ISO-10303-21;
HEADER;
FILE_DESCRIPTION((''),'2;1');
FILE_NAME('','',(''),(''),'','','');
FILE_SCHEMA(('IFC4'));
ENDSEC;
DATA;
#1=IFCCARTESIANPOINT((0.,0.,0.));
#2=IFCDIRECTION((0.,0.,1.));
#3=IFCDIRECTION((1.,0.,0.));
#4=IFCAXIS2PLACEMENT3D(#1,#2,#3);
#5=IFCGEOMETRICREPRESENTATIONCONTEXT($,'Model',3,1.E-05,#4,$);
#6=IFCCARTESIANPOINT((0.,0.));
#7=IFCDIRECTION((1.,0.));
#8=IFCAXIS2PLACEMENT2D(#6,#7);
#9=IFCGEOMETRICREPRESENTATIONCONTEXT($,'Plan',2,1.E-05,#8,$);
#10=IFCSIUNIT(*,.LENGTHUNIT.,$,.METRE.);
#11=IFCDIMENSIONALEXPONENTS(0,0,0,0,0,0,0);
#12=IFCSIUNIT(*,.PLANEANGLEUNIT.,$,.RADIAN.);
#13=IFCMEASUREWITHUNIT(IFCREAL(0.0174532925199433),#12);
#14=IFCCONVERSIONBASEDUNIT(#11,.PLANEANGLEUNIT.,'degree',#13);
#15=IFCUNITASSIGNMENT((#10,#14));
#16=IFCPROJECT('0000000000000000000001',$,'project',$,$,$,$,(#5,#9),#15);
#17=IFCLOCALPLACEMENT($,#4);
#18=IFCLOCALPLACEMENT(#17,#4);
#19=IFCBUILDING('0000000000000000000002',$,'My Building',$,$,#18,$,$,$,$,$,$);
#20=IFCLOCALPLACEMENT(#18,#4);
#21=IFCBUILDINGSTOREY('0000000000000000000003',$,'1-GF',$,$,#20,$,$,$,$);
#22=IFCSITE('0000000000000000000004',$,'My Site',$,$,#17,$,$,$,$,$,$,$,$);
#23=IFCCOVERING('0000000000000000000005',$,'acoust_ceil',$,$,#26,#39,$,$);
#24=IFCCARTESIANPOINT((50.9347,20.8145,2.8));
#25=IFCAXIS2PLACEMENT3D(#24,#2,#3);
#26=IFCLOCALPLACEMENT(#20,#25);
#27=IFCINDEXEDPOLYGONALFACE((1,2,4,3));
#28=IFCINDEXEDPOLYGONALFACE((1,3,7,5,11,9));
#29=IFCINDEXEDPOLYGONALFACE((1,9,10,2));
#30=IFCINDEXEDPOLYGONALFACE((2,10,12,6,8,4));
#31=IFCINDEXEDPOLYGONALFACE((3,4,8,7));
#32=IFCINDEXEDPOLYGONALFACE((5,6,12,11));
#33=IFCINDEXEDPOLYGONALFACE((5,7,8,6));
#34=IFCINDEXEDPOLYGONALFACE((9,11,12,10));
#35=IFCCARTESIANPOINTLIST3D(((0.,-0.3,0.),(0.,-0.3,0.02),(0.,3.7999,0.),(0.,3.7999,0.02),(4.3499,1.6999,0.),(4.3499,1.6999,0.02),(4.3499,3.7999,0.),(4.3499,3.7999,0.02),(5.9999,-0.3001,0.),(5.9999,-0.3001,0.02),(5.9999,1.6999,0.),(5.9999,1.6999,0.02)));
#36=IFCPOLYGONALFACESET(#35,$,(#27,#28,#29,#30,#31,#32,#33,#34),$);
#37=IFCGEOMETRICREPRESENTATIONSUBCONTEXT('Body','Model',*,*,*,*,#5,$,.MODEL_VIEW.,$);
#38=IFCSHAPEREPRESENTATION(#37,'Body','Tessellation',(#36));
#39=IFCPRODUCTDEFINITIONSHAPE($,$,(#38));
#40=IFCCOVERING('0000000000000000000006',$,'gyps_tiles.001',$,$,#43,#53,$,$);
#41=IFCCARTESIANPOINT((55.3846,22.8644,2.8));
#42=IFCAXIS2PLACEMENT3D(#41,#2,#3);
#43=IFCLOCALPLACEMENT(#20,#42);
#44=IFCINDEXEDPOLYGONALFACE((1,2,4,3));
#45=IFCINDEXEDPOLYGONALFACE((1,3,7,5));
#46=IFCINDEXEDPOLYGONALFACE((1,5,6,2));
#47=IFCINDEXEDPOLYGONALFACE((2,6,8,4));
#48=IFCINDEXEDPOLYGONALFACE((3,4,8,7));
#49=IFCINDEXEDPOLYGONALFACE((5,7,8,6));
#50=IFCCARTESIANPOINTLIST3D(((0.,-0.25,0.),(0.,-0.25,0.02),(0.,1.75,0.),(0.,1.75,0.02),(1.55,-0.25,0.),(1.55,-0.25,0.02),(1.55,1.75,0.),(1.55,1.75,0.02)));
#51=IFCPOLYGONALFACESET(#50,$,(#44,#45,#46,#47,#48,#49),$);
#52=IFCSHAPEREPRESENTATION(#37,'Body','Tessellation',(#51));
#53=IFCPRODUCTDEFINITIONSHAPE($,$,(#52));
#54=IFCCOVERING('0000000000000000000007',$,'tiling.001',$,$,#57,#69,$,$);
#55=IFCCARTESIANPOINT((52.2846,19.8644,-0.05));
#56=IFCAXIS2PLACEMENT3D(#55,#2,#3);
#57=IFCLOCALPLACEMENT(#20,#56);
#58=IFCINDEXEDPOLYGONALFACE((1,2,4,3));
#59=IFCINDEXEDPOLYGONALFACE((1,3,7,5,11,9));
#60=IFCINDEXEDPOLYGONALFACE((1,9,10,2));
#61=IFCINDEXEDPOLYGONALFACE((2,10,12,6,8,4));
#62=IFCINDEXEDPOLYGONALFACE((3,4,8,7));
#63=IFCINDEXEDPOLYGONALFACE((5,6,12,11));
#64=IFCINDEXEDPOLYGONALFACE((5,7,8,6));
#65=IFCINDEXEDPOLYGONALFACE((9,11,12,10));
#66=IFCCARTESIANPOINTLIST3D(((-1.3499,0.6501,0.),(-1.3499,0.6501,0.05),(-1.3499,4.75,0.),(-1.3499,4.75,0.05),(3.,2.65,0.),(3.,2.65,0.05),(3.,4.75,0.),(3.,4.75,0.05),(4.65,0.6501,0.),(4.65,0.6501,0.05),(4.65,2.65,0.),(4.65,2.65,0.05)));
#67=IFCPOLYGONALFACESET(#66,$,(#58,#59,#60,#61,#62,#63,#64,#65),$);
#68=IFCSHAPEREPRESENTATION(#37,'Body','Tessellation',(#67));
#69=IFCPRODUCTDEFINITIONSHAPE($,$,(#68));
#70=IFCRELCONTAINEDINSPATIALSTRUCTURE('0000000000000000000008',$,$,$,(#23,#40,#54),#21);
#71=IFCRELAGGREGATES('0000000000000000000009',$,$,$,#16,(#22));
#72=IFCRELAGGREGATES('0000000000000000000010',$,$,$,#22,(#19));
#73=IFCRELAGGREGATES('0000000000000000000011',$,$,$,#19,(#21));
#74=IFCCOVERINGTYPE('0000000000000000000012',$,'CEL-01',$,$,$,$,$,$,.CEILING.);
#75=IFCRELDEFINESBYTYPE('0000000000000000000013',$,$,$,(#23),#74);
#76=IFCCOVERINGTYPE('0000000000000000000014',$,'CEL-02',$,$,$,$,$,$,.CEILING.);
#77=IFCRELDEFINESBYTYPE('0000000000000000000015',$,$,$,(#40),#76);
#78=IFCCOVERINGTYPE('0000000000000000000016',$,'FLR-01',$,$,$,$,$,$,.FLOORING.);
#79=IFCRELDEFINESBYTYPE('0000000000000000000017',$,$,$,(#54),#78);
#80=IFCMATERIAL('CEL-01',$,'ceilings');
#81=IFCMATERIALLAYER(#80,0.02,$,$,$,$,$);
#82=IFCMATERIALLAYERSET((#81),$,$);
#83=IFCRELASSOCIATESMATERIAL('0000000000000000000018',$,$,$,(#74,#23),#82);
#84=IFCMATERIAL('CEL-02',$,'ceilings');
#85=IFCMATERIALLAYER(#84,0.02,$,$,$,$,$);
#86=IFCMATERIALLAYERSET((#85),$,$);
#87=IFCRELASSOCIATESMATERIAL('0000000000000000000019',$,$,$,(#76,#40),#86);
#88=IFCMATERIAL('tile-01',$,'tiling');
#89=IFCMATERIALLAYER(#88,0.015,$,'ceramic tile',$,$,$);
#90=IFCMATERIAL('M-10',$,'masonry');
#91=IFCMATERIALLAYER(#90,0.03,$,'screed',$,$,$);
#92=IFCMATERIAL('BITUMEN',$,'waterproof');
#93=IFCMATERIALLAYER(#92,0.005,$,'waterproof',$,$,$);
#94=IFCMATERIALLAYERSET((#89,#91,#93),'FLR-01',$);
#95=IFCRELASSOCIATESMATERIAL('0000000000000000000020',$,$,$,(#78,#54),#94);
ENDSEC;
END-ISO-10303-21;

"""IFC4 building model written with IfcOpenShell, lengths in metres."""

from ifc_helpers import new_model, entity, si_unit, converted_unit, frame, origin_with_axes, origin_2d_with_axis, place, context, subcontext, project, spatial, line, indexed_curve, outline, extrude, material, layer, layer_set, layer_usage, type_object, element, save


model = new_model("IFC4")

# Units and contexts
model_context = context("Model", 3, precision=1e-05, world=origin_with_axes())
plan_context = context("Plan", 2, precision=1e-05, world=origin_2d_with_axis())
body_context_1 = subcontext(model_context, "Body", "Model", "MODEL_VIEW")
ifc_project = project(units=[si_unit("LENGTHUNIT", "METRE"), converted_unit("PLANEANGLEUNIT", "degree", entity("IfcReal", 0.0174532925199433), si_unit("PLANEANGLEUNIT", "RADIAN"), dimensions=[0, 0, 0, 0, 0, 0, 0])], contexts=[model_context, plan_context])

# Site, building, storey
site_placement = place(None, origin_with_axes())
site = spatial("IfcSite", under=ifc_project, at=site_placement, Name="My Site")
building_placement = place(site_placement, origin_with_axes())
building = spatial("IfcBuilding", under=site, at=building_placement, Name="My Building")
storey_placement = place(building_placement, origin_with_axes())
storey = spatial("IfcBuildingStorey", under=building, at=storey_placement, Name="1-GF")

# Coverings
ifc_material_1 = material(Name="CEL-01", Category="ceilings")
ifc_layer_1 = layer(ifc_material_1, 0.02)
ifc_layer_set_1 = layer_set([ifc_layer_1])
ifc_layer_usage_1 = layer_usage(ifc_layer_set_1, "AXIS3", "POSITIVE", 0.0)
covering_type_1 = type_object("IfcCoveringType", Name="CEL-01", PredefinedType="CEILING", material=ifc_layer_set_1)
covering_1_placement = place(storey_placement, frame((50.9347, 20.8145, 2.8), z_axis=(0.0, 0.0, 1.0), x_axis=(1.0, 0.0, 0.0)))
element("IfcCovering", 1, at=covering_1_placement, inside=storey, type_object=covering_type_1, material=ifc_layer_usage_1, Name="acoust_ceil", context=body_context_1, shape_type="SweptSolid", body=[
    extrude(outline(indexed_curve([(0.0, -0.3), (4.3499, 3.7999), (0.0, 3.7999), (4.3499, 1.6999), (5.9999, 1.6999), (5.9999, -0.3001)], segments=[line(2, 3), line(3, 1), line(1, 6), line(6, 5), line(5, 4), line(4, 2)], self_intersect=False)), None, (0.0, 0.0, 1.0), 0.02),
])
ifc_material_2 = material(Name="CEL-02", Category="ceilings")
ifc_layer_2 = layer(ifc_material_2, 0.02)
ifc_layer_set_2 = layer_set([ifc_layer_2])
ifc_layer_usage_2 = layer_usage(ifc_layer_set_2, "AXIS3", "POSITIVE", 0.0)
covering_type_2 = type_object("IfcCoveringType", Name="CEL-02", PredefinedType="CEILING", material=ifc_layer_set_2)
covering_2_placement = place(storey_placement, frame((55.3846, 22.8644, 2.8), z_axis=(0.0, 0.0, 1.0), x_axis=(1.0, 0.0, 0.0)))
element("IfcCovering", 2, at=covering_2_placement, inside=storey, type_object=covering_type_2, material=ifc_layer_usage_2, Name="gyps_tiles.001", context=body_context_1, shape_type="SweptSolid", body=[
    extrude(outline(indexed_curve([(0.0, -0.25), (1.55, -0.25), (1.55, 1.75), (0.0, 1.75)], segments=[line(3, 2), line(2, 1), line(1, 4), line(4, 3)], self_intersect=False)), None, (0.0, 0.0, 1.0), 0.02),
])
ifc_material_3 = material(Name="tile-01", Category="tiling")
ifc_layer_3 = layer(ifc_material_3, 0.015, Name="ceramic tile")
ifc_material_4 = material(Name="M-10", Category="masonry")
ifc_layer_4 = layer(ifc_material_4, 0.03, Name="screed")
ifc_material_5 = material(Name="BITUMEN", Category="waterproof")
ifc_layer_5 = layer(ifc_material_5, 0.005, Name="waterproof")
ifc_layer_set_3 = layer_set([ifc_layer_3, ifc_layer_4, ifc_layer_5], Name="FLR-01")
ifc_layer_usage_3 = layer_usage(ifc_layer_set_3, "AXIS3", "POSITIVE", 0.0)
covering_type_3 = type_object("IfcCoveringType", Name="FLR-01", PredefinedType="FLOORING", material=ifc_layer_set_3)
covering_3_placement = place(storey_placement, frame((52.2846, 19.8644, -0.05), z_axis=(0.0, 0.0, 1.0), x_axis=(1.0, 0.0, 0.0)))
element("IfcCovering", 3, at=covering_3_placement, inside=storey, type_object=covering_type_3, material=ifc_layer_usage_3, Name="tiling.001", context=body_context_1, shape_type="SweptSolid", body=[
    extrude(outline(indexed_curve([(3.0, 4.75), (4.65, 0.6501), (-1.3499, 0.6501), (-1.3499, 4.75), (3.0, 2.65), (4.65, 2.65)], segments=[line(3, 2), line(2, 6), line(6, 5), line(5, 1), line(1, 4), line(4, 3)], self_intersect=False)), None, (0.0, 0.0, 1.0), 0.05),
])

save(model, "model.ifc")
